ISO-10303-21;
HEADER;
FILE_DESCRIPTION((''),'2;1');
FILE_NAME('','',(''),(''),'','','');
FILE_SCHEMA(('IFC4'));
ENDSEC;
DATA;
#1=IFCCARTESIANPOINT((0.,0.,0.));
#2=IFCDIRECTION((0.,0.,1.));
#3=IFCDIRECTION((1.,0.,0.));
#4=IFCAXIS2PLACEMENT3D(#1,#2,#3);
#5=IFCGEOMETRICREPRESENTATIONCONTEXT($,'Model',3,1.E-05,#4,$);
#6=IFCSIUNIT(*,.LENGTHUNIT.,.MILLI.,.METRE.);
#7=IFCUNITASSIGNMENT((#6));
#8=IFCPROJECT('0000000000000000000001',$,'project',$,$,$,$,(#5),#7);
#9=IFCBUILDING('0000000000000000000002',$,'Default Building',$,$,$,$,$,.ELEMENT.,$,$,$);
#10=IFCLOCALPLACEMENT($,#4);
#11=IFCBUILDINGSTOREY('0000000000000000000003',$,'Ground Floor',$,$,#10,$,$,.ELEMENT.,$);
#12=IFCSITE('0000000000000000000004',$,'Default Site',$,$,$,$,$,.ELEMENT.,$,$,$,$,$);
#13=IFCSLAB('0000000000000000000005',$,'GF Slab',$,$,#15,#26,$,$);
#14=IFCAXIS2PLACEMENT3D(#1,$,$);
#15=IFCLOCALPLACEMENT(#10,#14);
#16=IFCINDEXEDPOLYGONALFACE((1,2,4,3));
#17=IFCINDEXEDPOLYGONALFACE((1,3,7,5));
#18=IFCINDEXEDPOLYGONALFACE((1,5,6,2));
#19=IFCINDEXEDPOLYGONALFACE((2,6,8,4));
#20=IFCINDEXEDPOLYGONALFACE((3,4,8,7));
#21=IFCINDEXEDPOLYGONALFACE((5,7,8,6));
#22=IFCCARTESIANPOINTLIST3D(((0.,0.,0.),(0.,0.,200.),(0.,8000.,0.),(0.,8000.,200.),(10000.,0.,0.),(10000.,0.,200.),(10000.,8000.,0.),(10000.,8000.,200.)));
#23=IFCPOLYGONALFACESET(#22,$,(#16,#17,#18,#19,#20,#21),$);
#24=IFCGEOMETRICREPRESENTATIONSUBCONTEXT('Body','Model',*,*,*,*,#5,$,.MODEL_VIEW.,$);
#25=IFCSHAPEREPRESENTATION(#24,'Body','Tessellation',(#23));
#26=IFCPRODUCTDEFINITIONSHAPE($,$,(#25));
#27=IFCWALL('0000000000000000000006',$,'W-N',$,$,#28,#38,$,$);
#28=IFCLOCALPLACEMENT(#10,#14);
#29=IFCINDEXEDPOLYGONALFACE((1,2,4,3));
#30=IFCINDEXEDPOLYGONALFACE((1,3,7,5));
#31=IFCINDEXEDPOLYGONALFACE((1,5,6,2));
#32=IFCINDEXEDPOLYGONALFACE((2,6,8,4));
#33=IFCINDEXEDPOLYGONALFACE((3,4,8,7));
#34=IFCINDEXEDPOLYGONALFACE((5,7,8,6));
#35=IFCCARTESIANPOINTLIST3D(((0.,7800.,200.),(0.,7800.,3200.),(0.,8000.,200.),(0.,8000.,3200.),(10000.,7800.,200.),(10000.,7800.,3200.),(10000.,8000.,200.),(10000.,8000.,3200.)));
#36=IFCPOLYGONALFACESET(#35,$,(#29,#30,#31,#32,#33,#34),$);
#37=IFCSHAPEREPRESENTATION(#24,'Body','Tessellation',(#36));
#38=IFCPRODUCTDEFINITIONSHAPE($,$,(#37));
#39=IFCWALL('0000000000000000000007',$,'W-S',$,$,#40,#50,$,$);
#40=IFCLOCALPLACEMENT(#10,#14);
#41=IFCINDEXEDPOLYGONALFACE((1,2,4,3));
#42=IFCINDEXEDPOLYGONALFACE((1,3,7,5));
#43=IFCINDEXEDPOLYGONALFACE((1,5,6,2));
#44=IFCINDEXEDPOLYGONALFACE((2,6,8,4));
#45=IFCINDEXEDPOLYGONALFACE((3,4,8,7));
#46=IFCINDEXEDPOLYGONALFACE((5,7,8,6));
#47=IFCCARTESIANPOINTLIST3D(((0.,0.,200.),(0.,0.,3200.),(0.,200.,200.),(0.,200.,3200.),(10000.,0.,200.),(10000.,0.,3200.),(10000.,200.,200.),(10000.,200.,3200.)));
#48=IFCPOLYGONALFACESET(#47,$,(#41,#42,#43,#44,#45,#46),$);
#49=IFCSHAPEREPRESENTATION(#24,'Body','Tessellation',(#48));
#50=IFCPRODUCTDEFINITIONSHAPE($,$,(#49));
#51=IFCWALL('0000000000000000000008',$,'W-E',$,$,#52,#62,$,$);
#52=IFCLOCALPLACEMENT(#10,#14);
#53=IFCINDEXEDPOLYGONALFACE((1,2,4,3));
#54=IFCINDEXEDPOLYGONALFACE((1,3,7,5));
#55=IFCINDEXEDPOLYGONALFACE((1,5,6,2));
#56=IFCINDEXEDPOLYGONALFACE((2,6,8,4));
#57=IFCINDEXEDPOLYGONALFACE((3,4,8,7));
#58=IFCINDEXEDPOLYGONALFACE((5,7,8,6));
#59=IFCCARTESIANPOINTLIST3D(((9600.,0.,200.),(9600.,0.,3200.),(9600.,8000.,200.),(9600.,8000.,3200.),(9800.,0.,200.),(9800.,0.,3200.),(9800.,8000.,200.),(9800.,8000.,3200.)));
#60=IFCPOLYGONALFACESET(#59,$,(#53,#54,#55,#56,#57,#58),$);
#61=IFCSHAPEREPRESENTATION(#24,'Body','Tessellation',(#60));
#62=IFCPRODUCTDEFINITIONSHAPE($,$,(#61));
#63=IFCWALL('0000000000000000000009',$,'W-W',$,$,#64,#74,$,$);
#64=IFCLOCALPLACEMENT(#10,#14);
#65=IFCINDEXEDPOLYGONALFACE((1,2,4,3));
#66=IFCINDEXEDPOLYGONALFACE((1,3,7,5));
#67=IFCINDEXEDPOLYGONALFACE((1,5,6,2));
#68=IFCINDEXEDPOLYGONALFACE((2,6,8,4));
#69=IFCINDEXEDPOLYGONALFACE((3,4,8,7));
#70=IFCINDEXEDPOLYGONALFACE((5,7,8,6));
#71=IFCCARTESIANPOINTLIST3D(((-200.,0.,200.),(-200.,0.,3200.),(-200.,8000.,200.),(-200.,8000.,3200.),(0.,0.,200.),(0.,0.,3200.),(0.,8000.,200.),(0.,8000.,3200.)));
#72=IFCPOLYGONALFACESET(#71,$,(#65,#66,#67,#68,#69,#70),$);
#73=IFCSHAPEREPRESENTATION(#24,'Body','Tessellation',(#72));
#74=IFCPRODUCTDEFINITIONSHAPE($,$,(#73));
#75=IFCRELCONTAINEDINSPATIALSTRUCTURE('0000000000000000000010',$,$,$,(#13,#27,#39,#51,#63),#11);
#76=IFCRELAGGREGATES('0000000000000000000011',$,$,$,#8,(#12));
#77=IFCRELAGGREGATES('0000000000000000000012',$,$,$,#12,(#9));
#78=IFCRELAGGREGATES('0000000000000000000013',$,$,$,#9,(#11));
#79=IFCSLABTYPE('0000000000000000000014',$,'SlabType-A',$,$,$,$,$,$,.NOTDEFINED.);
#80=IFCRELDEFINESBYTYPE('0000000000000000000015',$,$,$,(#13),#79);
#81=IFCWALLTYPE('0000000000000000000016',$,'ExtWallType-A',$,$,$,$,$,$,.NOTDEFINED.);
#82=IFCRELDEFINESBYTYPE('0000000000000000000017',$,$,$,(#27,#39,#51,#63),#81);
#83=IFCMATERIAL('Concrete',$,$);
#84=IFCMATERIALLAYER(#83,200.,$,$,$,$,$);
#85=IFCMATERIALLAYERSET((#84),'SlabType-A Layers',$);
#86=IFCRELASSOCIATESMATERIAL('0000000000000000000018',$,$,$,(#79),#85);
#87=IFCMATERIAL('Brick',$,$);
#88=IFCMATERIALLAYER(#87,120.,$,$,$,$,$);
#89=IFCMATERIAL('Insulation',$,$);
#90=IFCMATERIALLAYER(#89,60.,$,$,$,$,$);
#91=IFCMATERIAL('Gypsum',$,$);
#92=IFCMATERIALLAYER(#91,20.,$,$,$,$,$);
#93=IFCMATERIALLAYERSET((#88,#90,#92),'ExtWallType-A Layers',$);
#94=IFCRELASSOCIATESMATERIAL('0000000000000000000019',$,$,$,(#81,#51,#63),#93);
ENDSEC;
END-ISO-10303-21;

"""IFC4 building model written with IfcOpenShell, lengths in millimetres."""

from ifc_helpers import new_model, si_unit, frame, origin_with_axes, place, context, subcontext, project, spatial, polyline, outline, extrude, material, layer, layer_set, layer_usage, type_object, element, save


model = new_model("IFC4")

# Units and contexts
model_context = context("Model", 3, precision=1e-05, world=origin_with_axes())
body_context = subcontext(model_context, "Body", "Model", "MODEL_VIEW")
ifc_project = project(units=[si_unit("LENGTHUNIT", "METRE", prefix="MILLI")], contexts=[model_context])

# Site, building, storey
site = spatial("IfcSite", under=ifc_project, Name="Default Site", CompositionType="ELEMENT")
building = spatial("IfcBuilding", under=site, Name="Default Building", CompositionType="ELEMENT")
storey_placement = place(None, origin_with_axes())
storey = spatial("IfcBuildingStorey", under=building, at=storey_placement, Name="Ground Floor", CompositionType="ELEMENT")

# Slab
ifc_material_1 = material(Name="Concrete")
ifc_layer_1 = layer(ifc_material_1, 200.0)
ifc_layer_set_1 = layer_set([ifc_layer_1], Name="SlabType-A Layers")
slab_type = type_object("IfcSlabType", Name="SlabType-A", PredefinedType="NOTDEFINED", material=ifc_layer_set_1)
slab_placement = place(storey_placement, origin_with_axes())
element("IfcSlab", 1, at=slab_placement, inside=storey, type_object=slab_type, Name="GF Slab", context=body_context, shape_type="SweptSolid", body=[
    extrude(outline(polyline([(0.0, 0.0), (10000.0, 0.0), (10000.0, 8000.0), (0.0, 8000.0), (0.0, 0.0)])), origin_with_axes(), (0.0, 0.0, 1.0), 200.0),
])

# Walls
ifc_material_2 = material(Name="Brick")
ifc_layer_2 = layer(ifc_material_2, 120.0)
ifc_material_3 = material(Name="Insulation")
ifc_layer_3 = layer(ifc_material_3, 60.0)
ifc_material_4 = material(Name="Gypsum")
ifc_layer_4 = layer(ifc_material_4, 20.0)
ifc_layer_set_2 = layer_set([ifc_layer_2, ifc_layer_3, ifc_layer_4], Name="ExtWallType-A Layers")
wall_type = type_object("IfcWallType", Name="ExtWallType-A", PredefinedType="NOTDEFINED", material=ifc_layer_set_2)
wall_1_placement = place(storey_placement, frame((0.0, 0.0, 200.0), z_axis=(0.0, 0.0, 1.0), x_axis=(1.0, 0.0, 0.0)))
element("IfcWall", 2, at=wall_1_placement, inside=storey, type_object=wall_type, Name="W-N", context=body_context, shape_type="SweptSolid", body=[
    extrude(outline(polyline([(0.0, 7800.0), (10000.0, 7800.0), (10000.0, 8000.0), (0.0, 8000.0), (0.0, 7800.0)])), origin_with_axes(), (0.0, 0.0, 1.0), 3000.0),
])
wall_2_placement = place(storey_placement, frame((0.0, 0.0, 200.0), z_axis=(0.0, 0.0, 1.0), x_axis=(1.0, 0.0, 0.0)))
element("IfcWall", 3, at=wall_2_placement, inside=storey, type_object=wall_type, Name="W-S", context=body_context, shape_type="SweptSolid", body=[
    extrude(outline(polyline([(0.0, 0.0), (10000.0, 0.0), (10000.0, 200.0), (0.0, 200.0), (0.0, 0.0)])), origin_with_axes(), (0.0, 0.0, 1.0), 3000.0),
])
ifc_layer_usage = layer_usage(ifc_layer_set_2, "AXIS2", "POSITIVE", 0.0)
wall_3_placement = place(storey_placement, frame((0.0, 0.0, 200.0), z_axis=(0.0, 0.0, 1.0), x_axis=(1.0, 0.0, 0.0)))
element("IfcWall", 4, at=wall_3_placement, inside=storey, type_object=wall_type, material=ifc_layer_usage, Name="W-E", context=body_context, shape_type="SweptSolid", body=[
    extrude(outline(polyline([(9800.0, 0.0), (9800.0, 8000.0), (9600.0, 8000.0), (9600.0, 0.0), (9800.0, 0.0)])), origin_with_axes(), (0.0, 0.0, 1.0), 3000.0),
])
wall_4_placement = place(storey_placement, frame((0.0, 0.0, 200.0), z_axis=(0.0, 0.0, 1.0), x_axis=(1.0, 0.0, 0.0)))
element("IfcWall", 5, at=wall_4_placement, inside=storey, type_object=wall_type, material=ifc_layer_usage, Name="W-W", context=body_context, shape_type="SweptSolid", body=[
    extrude(outline(polyline([(0.0, 0.0), (0.0, 8000.0), (-200.0, 8000.0), (-200.0, 0.0), (0.0, 0.0)])), origin_with_axes(), (0.0, 0.0, 1.0), 3000.0),
])

save(model, "model.ifc")
